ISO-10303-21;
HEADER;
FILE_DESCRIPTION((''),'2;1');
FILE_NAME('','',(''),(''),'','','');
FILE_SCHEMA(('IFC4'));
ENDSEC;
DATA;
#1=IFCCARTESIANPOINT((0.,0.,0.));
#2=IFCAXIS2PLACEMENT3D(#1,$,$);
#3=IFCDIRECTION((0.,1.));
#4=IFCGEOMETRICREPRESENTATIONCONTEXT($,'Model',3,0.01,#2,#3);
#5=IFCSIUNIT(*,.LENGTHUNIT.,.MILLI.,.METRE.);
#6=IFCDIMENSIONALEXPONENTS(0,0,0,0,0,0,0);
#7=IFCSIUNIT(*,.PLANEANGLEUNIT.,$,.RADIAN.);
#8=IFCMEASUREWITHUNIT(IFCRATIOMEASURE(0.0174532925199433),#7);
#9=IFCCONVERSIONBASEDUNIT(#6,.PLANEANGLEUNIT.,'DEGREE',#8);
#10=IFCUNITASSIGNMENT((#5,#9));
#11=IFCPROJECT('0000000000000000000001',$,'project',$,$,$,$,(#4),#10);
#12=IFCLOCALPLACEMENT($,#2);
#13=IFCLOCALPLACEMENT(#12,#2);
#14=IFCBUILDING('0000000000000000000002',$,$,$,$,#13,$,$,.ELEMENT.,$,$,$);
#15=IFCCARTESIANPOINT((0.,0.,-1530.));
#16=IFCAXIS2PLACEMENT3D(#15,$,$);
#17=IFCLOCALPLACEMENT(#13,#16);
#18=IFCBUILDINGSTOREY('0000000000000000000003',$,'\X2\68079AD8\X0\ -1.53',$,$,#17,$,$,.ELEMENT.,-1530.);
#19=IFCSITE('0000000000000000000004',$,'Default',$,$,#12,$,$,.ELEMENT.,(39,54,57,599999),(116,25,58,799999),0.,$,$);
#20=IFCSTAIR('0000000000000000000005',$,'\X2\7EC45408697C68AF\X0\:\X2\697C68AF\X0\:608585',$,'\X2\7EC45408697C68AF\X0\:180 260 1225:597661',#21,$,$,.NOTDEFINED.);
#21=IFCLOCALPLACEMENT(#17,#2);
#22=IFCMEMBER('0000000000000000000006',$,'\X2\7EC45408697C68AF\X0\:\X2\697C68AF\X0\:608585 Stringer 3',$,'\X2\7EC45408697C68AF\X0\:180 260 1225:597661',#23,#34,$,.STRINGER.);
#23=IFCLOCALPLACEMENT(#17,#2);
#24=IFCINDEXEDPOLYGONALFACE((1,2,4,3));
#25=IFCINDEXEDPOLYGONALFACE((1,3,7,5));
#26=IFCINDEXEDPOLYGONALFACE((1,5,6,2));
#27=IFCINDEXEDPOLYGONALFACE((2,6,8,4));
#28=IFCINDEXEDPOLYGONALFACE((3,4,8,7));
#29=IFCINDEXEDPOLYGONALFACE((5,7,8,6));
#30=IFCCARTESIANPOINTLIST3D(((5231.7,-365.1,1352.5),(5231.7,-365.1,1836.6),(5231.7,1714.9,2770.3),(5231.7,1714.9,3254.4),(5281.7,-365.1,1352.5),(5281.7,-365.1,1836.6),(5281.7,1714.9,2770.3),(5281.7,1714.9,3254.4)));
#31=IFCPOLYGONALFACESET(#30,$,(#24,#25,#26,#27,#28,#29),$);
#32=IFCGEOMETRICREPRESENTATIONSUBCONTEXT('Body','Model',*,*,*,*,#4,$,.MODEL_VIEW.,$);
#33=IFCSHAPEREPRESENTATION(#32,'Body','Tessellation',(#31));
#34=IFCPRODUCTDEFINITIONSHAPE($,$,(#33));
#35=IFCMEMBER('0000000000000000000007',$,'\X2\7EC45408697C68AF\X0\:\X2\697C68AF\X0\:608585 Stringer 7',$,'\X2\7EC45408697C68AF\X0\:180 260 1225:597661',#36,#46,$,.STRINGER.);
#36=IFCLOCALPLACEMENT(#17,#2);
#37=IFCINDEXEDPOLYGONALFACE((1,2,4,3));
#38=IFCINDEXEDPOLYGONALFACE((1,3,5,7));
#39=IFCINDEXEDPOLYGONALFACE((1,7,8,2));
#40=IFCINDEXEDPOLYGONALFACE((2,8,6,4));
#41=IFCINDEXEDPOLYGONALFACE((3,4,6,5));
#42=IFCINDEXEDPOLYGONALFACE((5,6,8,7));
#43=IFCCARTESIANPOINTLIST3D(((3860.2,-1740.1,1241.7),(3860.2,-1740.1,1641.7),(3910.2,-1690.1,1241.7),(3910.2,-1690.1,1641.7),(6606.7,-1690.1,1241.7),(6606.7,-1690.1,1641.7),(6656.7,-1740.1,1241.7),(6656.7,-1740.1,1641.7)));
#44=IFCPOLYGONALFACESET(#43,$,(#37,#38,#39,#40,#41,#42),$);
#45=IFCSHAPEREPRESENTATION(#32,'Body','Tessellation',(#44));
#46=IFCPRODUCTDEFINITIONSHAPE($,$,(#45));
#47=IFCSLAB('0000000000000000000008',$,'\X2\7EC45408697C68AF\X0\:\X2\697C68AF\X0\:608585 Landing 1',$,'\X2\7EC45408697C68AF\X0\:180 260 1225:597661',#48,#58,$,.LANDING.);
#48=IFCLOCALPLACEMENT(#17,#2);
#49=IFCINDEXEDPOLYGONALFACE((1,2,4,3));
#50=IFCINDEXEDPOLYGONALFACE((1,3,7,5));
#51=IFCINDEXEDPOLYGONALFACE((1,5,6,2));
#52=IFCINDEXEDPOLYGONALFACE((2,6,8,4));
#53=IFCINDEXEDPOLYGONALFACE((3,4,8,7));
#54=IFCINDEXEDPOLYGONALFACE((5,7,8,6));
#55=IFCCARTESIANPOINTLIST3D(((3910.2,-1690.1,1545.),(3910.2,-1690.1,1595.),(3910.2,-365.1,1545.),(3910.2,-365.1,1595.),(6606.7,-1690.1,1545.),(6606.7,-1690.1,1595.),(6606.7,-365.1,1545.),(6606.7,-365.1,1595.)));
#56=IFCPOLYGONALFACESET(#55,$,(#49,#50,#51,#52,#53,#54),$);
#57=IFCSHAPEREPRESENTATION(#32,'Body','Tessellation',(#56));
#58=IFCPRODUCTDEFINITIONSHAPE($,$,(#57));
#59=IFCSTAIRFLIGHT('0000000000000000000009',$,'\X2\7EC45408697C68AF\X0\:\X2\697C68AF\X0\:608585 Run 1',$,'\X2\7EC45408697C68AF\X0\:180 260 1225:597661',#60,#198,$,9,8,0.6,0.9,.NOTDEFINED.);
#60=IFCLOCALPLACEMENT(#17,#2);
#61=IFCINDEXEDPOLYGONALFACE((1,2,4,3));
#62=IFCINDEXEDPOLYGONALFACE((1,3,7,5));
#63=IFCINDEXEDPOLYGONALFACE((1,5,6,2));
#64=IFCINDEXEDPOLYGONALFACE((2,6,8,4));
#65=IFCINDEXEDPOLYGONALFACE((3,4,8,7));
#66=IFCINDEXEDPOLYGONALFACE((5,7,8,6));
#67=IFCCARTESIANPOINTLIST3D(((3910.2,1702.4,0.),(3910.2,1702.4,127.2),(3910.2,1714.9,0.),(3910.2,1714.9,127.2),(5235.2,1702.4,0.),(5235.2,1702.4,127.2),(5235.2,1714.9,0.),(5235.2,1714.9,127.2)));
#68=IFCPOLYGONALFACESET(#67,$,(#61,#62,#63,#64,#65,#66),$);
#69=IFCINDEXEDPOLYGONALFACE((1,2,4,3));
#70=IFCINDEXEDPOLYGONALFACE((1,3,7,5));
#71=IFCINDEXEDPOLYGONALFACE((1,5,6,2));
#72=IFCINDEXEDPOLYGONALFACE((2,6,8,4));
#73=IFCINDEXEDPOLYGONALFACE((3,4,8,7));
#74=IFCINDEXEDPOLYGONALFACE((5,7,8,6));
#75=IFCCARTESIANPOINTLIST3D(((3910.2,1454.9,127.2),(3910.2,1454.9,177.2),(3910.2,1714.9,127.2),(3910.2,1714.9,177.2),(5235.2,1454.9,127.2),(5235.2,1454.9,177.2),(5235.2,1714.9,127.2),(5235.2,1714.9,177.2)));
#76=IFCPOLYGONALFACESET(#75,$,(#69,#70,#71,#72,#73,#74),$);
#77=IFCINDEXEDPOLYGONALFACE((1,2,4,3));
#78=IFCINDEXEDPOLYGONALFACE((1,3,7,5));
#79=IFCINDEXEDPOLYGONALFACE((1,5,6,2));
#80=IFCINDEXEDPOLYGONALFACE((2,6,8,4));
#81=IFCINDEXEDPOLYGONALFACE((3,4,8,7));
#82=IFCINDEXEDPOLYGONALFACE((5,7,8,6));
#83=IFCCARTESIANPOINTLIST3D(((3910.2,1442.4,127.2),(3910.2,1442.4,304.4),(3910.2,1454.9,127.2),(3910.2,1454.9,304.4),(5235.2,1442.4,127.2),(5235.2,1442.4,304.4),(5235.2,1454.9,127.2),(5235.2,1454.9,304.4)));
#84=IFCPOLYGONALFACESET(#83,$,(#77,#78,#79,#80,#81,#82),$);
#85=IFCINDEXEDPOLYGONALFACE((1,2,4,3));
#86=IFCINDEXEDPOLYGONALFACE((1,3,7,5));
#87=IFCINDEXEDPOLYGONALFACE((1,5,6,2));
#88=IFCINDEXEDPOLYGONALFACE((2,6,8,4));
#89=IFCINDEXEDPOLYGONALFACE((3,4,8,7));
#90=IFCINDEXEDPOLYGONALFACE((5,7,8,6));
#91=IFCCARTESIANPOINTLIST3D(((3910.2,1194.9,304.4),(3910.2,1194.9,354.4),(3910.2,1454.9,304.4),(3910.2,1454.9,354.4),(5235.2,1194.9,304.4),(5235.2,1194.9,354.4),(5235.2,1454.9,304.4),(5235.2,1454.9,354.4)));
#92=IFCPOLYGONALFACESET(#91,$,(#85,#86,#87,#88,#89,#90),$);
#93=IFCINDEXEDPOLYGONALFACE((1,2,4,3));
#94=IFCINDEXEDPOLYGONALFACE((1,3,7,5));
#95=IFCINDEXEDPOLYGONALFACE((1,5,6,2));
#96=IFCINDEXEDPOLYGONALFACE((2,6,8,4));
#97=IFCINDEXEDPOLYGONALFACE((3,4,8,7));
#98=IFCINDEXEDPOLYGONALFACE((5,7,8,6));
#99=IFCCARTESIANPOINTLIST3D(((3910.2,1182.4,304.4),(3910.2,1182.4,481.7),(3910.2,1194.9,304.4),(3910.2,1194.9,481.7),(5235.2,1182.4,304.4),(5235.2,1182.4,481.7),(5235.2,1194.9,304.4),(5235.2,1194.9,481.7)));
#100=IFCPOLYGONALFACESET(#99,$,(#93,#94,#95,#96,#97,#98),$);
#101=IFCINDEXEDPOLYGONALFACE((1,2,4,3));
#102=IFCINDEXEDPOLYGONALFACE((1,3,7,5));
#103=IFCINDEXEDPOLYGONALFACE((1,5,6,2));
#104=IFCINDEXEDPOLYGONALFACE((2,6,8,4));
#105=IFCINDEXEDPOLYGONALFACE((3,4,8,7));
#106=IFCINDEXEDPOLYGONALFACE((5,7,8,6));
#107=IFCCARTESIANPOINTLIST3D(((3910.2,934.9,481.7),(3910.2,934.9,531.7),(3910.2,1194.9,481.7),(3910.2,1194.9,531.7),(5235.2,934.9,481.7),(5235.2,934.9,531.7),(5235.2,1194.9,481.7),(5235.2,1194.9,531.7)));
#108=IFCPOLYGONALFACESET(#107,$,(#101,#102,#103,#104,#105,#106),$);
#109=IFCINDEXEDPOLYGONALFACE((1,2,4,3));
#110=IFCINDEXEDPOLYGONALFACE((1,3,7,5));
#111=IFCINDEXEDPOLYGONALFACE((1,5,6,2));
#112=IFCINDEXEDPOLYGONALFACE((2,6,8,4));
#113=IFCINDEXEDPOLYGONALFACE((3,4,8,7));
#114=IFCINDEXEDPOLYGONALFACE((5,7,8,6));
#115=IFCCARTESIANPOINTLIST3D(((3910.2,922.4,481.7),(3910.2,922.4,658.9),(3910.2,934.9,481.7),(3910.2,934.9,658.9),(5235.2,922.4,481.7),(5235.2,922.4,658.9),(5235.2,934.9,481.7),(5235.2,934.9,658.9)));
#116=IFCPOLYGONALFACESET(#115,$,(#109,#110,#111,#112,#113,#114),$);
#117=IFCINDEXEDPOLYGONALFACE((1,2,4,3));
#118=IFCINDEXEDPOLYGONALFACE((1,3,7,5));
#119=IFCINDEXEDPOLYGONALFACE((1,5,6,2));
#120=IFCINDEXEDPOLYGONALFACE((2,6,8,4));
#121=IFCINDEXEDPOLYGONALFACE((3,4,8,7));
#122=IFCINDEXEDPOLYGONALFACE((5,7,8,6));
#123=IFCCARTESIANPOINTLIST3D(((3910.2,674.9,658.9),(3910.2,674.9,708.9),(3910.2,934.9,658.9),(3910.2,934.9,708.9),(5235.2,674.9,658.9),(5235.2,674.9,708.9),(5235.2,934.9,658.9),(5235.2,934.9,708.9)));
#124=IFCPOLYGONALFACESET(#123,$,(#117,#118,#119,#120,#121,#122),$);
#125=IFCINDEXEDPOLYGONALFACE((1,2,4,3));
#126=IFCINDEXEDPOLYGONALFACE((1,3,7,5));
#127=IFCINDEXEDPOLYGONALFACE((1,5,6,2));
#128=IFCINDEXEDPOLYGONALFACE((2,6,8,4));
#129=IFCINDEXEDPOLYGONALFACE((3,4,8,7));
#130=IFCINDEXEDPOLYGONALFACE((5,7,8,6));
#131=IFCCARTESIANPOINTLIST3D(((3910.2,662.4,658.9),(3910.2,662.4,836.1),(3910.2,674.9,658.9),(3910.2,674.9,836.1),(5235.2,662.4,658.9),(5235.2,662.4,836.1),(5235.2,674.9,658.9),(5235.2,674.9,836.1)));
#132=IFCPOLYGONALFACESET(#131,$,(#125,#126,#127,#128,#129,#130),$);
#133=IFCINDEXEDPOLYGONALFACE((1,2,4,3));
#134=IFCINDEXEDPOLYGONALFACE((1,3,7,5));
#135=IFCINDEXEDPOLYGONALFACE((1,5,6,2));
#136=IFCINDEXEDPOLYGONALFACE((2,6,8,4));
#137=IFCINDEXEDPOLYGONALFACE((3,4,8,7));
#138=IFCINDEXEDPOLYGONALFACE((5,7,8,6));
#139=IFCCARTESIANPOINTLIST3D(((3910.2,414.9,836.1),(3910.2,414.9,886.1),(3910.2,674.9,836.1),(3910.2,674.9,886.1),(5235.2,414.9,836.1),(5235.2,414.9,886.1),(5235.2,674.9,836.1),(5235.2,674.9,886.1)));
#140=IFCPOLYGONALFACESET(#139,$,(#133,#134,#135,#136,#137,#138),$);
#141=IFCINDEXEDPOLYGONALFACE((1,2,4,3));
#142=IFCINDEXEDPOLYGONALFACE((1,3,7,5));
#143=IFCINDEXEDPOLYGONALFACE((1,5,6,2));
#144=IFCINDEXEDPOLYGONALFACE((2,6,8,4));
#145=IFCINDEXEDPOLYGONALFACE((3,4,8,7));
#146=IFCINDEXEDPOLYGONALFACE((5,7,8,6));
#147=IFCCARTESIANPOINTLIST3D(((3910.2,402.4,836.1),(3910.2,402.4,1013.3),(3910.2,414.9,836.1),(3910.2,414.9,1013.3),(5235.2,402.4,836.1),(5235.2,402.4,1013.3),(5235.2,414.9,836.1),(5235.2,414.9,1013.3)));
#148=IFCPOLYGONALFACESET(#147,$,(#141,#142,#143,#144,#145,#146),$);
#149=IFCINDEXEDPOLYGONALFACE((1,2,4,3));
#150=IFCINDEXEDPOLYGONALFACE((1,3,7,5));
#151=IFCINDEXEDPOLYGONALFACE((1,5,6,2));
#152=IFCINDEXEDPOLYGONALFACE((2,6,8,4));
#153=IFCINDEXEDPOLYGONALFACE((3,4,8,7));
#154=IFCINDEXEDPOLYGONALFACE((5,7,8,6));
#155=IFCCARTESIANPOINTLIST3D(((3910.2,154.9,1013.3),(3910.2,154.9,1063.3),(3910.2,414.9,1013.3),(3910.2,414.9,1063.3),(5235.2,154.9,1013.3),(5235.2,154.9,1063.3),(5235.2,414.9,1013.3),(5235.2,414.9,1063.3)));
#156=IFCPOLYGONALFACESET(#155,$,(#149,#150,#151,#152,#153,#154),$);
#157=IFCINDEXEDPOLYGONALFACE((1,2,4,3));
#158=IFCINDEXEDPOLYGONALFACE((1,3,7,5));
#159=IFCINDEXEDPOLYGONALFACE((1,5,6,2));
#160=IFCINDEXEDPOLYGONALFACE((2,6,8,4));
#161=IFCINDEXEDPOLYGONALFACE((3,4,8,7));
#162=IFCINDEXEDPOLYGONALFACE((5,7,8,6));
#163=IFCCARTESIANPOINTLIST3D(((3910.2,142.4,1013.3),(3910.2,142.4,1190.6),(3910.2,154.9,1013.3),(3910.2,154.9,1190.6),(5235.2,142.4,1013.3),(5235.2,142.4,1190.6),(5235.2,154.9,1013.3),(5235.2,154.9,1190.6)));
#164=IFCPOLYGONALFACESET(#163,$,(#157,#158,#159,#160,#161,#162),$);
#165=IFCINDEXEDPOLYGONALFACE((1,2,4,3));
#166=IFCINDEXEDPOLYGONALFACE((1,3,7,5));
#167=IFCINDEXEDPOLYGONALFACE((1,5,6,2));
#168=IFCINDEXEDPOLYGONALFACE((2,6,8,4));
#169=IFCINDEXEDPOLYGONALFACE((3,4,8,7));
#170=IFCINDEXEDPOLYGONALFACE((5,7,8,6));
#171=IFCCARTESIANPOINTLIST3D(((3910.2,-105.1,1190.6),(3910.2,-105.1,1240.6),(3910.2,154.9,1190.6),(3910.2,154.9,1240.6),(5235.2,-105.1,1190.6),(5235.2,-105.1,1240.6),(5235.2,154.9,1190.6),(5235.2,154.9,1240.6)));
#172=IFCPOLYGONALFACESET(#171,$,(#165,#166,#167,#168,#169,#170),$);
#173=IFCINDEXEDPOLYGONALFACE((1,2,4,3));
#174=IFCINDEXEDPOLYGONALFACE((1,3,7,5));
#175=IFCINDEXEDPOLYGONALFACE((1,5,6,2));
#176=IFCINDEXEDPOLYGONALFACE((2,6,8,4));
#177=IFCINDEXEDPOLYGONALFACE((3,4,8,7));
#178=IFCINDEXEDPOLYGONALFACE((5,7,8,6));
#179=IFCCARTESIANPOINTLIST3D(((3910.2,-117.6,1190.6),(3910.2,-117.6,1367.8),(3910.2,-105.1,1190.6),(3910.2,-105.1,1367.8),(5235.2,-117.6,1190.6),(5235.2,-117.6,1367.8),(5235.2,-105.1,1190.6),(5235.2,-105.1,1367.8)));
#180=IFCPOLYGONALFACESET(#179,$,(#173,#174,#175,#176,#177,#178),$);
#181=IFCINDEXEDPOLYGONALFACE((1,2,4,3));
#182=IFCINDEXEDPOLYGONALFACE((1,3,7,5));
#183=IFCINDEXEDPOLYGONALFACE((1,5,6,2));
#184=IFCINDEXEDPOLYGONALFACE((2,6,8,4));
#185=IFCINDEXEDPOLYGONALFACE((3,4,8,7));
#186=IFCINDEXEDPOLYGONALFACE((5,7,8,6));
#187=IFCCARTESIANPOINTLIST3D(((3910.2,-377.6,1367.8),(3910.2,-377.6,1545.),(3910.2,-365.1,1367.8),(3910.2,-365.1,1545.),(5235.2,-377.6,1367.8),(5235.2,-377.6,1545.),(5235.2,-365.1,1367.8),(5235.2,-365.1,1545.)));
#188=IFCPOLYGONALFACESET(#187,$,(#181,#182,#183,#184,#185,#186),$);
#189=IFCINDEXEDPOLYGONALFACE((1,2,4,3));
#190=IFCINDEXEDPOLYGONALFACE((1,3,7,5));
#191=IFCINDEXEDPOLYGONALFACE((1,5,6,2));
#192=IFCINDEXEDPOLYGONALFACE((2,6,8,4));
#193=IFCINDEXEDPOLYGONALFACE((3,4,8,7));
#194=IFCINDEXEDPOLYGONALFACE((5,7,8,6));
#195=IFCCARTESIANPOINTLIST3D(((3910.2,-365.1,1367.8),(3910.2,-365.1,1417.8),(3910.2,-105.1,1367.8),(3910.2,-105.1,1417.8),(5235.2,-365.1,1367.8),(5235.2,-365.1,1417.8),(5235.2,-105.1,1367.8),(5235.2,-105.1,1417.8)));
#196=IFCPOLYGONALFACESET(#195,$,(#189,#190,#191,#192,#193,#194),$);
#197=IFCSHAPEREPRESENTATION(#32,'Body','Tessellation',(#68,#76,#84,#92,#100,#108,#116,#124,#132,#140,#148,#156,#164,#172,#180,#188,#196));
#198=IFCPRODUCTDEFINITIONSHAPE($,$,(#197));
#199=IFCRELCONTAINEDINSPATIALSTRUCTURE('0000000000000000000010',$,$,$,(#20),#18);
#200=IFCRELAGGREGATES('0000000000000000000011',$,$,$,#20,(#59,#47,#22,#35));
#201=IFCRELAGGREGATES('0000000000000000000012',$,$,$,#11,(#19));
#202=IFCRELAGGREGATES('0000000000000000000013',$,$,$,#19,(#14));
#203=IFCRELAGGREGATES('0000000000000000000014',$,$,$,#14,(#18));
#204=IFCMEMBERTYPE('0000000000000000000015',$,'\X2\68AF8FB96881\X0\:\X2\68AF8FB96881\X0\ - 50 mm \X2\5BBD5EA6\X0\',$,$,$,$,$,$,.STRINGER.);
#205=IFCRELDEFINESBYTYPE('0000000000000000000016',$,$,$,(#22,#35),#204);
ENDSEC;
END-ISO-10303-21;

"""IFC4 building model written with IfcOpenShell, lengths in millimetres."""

from ifc_helpers import new_model, entity, si_unit, converted_unit, direction, frame, frame_2d, origin, origin_2d_with_axis, place, context, subcontext, project, spatial, polyline, rectangle, outline, extrude, type_object, element, aggregate, save


model = new_model("IFC4")

# Units and contexts
model_context = context("Model", 3, precision=0.01, world=origin(), true_north=direction((0.0, 1.0)))
body_context = subcontext(model_context, "Body", "Model", "MODEL_VIEW")
ifc_project = project(units=[si_unit("LENGTHUNIT", "METRE", prefix="MILLI"), converted_unit("PLANEANGLEUNIT", "DEGREE", entity("IfcRatioMeasure", 0.0174532925199433), si_unit("PLANEANGLEUNIT", "RADIAN"), dimensions=[0, 0, 0, 0, 0, 0, 0])], contexts=[model_context])

# Site, building, storey
site_placement = place(None, origin())
site = spatial("IfcSite", under=ifc_project, at=site_placement, Name="Default", CompositionType="ELEMENT", RefLatitude=(39, 54, 57, 599999), RefLongitude=(116, 25, 58, 799999), RefElevation=0.0)
building_placement = place(site_placement, origin())
building = spatial("IfcBuilding", under=site, at=building_placement, CompositionType="ELEMENT")
storey_placement = place(building_placement, frame((0.0, 0.0, -1530.0)))
storey = spatial("IfcBuildingStorey", under=building, at=storey_placement, Name="标高 -1.53", CompositionType="ELEMENT", Elevation=-1530.0)

# Stair, members, slab, stair flight
stair_placement = place(storey_placement, origin())
stair = element("IfcStair", 1, at=stair_placement, inside=storey, Name="组合楼梯:楼梯:608585", ObjectType="组合楼梯:180 260 1225:597661", PredefinedType="NOTDEFINED")
member_type = type_object("IfcMemberType", Name="梯边梁:梯边梁 - 50 mm 宽度", PredefinedType="STRINGER")
member_1_placement = place(stair_placement, frame((5231.7, -365.1, 1352.5)))
member_1 = element("IfcMember", 2, at=member_1_placement, type_object=member_type, Name="组合楼梯:楼梯:608585 Stringer 3", ObjectType="组合楼梯:180 260 1225:597661", PredefinedType="STRINGER", context=body_context, shape_type="SweptSolid", body=[
    extrude(outline(polyline([(-1394.9, -200.0), (1122.3, -200.0), (1394.9, 200.0), (-1122.3, 200.0), (-1394.9, -200.0)])), frame((0.0, 1040.0, 950.9), z_axis=(1.0, 0.0, 0.0), x_axis=(0.0, 0.826302, 0.563227)), (0.0, 0.0, 1.0), 50.0),
])
member_2_placement = place(stair_placement, frame((3860.2, -1740.1, 1241.7)))
member_2 = element("IfcMember", 3, at=member_2_placement, type_object=member_type, Name="组合楼梯:楼梯:608585 Stringer 7", ObjectType="组合楼梯:180 260 1225:597661", PredefinedType="STRINGER", context=body_context, shape_type="SweptSolid", body=[
    extrude(outline(polyline([(-1398.3, -25.0), (1398.3, -25.0), (1348.3, 25.0), (-1348.3, 25.0), (-1398.3, -25.0)])), frame((1398.3, 25.0, 0.0)), (0.0, 0.0, 1.0), 400.0),
])
slab_placement = place(stair_placement, frame((3910.2, -1690.1, 0.0)))
slab = element("IfcSlab", 4, at=slab_placement, Name="组合楼梯:楼梯:608585 Landing 1", ObjectType="组合楼梯:180 260 1225:597661", PredefinedType="LANDING", context=body_context, shape_type="SweptSolid", body=[
    extrude(rectangle(XDim=2696.6, YDim=1325.0, at=frame_2d((0.0, 220.8), x_axis=(1.0, 0.0))), frame((1348.3, 883.3, 1545.0), z_axis=(0.0, 0.0, 1.0), x_axis=(-1.0, 0.0, 0.0)), (0.0, 0.0, 1.0), 50.0),
])
stair_flight_1_placement = place(stair_placement, frame((3910.2, -377.6, 0.0)))
stair_flight_1 = element("IfcStairFlight", 5, at=stair_flight_1_placement, Name="组合楼梯:楼梯:608585 Run 1", ObjectType="组合楼梯:180 260 1225:597661", NumberOfRisers=9, NumberOfTreads=8, PredefinedType="NOTDEFINED", RiserHeight=0.6, TreadLength=0.9, context=body_context, shape_type="SweptSolid", body=[
    extrude(rectangle(XDim=1325.0, YDim=12.5, at=frame_2d((0.0, 0.0), x_axis=(1.0, 0.0))), frame((662.5, 2086.2, 0.0)), (0.0, 0.0, 1.0), 127.2),
    extrude(rectangle(XDim=260.0, YDim=1325.0, at=frame_2d((0.0, 0.0), x_axis=(1.0, 0.0))), frame((662.5, 1962.5, 127.2), z_axis=(0.0, 0.0, 1.0), x_axis=(0.0, 1.0, 0.0)), (0.0, 0.0, 1.0), 50.0),
    extrude(rectangle(XDim=1325.0, YDim=12.5, at=frame_2d((0.0, 0.0), x_axis=(1.0, 0.0))), frame((662.5, 1826.2, 127.2)), (0.0, 0.0, 1.0), 177.2),
    extrude(rectangle(XDim=260.0, YDim=1325.0, at=frame_2d((0.0, 0.0), x_axis=(1.0, 0.0))), frame((662.5, 1702.5, 304.4), z_axis=(0.0, 0.0, 1.0), x_axis=(0.0, 1.0, 0.0)), (0.0, 0.0, 1.0), 50.0),
    extrude(rectangle(XDim=1325.0, YDim=12.5, at=frame_2d((0.0, 0.0), x_axis=(1.0, 0.0))), frame((662.5, 1566.2, 304.4)), (0.0, 0.0, 1.0), 177.2),
    extrude(rectangle(XDim=260.0, YDim=1325.0, at=frame_2d((0.0, 0.0), x_axis=(1.0, 0.0))), frame((662.5, 1442.5, 481.7), z_axis=(0.0, 0.0, 1.0), x_axis=(0.0, 1.0, 0.0)), (0.0, 0.0, 1.0), 50.0),
    extrude(rectangle(XDim=1325.0, YDim=12.5, at=frame_2d((0.0, 0.0), x_axis=(1.0, 0.0))), frame((662.5, 1306.2, 481.7)), (0.0, 0.0, 1.0), 177.2),
    extrude(rectangle(XDim=260.0, YDim=1325.0, at=frame_2d((0.0, 0.0), x_axis=(1.0, 0.0))), frame((662.5, 1182.5, 658.9), z_axis=(0.0, 0.0, 1.0), x_axis=(0.0, 1.0, 0.0)), (0.0, 0.0, 1.0), 50.0),
    extrude(rectangle(XDim=1325.0, YDim=12.5, at=frame_2d((0.0, 0.0), x_axis=(1.0, 0.0))), frame((662.5, 1046.2, 658.9)), (0.0, 0.0, 1.0), 177.2),
    extrude(rectangle(XDim=260.0, YDim=1325.0, at=frame_2d((0.0, 0.0), x_axis=(1.0, 0.0))), frame((662.5, 922.5, 836.1), z_axis=(0.0, 0.0, 1.0), x_axis=(0.0, 1.0, 0.0)), (0.0, 0.0, 1.0), 50.0),
    extrude(rectangle(XDim=1325.0, YDim=12.5, at=frame_2d((0.0, 0.0), x_axis=(1.0, 0.0))), frame((662.5, 786.3, 836.1)), (0.0, 0.0, 1.0), 177.2),
    extrude(rectangle(XDim=260.0, YDim=1325.0, at=frame_2d((0.0, 0.0), x_axis=(1.0, 0.0))), frame((662.5, 662.5, 1013.3), z_axis=(0.0, 0.0, 1.0), x_axis=(0.0, 1.0, 0.0)), (0.0, 0.0, 1.0), 50.0),
    extrude(rectangle(XDim=1325.0, YDim=12.5, at=frame_2d((0.0, 0.0), x_axis=(1.0, 0.0))), frame((662.5, 526.2, 1013.3)), (0.0, 0.0, 1.0), 177.2),
    extrude(rectangle(XDim=260.0, YDim=1325.0, at=frame_2d((0.0, 0.0), x_axis=(1.0, 0.0))), frame((662.5, 402.5, 1190.6), z_axis=(0.0, 0.0, 1.0), x_axis=(0.0, 1.0, 0.0)), (0.0, 0.0, 1.0), 50.0),
    extrude(rectangle(XDim=1325.0, YDim=12.5, at=frame_2d((0.0, 0.0), x_axis=(1.0, 0.0))), frame((662.5, 266.3, 1190.6)), (0.0, 0.0, 1.0), 177.2),
    extrude(rectangle(XDim=1325.0, YDim=12.5, at=origin_2d_with_axis()), frame((662.5, 6.2, 1367.8)), (0.0, 0.0, 1.0), 177.2),
    extrude(rectangle(XDim=260.0, YDim=1325.0, at=frame_2d((0.0, 0.0), x_axis=(1.0, 0.0))), frame((662.5, 142.5, 1367.8), z_axis=(0.0, 0.0, 1.0), x_axis=(0.0, 1.0, 0.0)), (0.0, 0.0, 1.0), 50.0),
])
aggregate(stair, [stair_flight_1, slab, member_1, member_2])

save(model, "model.ifc")
